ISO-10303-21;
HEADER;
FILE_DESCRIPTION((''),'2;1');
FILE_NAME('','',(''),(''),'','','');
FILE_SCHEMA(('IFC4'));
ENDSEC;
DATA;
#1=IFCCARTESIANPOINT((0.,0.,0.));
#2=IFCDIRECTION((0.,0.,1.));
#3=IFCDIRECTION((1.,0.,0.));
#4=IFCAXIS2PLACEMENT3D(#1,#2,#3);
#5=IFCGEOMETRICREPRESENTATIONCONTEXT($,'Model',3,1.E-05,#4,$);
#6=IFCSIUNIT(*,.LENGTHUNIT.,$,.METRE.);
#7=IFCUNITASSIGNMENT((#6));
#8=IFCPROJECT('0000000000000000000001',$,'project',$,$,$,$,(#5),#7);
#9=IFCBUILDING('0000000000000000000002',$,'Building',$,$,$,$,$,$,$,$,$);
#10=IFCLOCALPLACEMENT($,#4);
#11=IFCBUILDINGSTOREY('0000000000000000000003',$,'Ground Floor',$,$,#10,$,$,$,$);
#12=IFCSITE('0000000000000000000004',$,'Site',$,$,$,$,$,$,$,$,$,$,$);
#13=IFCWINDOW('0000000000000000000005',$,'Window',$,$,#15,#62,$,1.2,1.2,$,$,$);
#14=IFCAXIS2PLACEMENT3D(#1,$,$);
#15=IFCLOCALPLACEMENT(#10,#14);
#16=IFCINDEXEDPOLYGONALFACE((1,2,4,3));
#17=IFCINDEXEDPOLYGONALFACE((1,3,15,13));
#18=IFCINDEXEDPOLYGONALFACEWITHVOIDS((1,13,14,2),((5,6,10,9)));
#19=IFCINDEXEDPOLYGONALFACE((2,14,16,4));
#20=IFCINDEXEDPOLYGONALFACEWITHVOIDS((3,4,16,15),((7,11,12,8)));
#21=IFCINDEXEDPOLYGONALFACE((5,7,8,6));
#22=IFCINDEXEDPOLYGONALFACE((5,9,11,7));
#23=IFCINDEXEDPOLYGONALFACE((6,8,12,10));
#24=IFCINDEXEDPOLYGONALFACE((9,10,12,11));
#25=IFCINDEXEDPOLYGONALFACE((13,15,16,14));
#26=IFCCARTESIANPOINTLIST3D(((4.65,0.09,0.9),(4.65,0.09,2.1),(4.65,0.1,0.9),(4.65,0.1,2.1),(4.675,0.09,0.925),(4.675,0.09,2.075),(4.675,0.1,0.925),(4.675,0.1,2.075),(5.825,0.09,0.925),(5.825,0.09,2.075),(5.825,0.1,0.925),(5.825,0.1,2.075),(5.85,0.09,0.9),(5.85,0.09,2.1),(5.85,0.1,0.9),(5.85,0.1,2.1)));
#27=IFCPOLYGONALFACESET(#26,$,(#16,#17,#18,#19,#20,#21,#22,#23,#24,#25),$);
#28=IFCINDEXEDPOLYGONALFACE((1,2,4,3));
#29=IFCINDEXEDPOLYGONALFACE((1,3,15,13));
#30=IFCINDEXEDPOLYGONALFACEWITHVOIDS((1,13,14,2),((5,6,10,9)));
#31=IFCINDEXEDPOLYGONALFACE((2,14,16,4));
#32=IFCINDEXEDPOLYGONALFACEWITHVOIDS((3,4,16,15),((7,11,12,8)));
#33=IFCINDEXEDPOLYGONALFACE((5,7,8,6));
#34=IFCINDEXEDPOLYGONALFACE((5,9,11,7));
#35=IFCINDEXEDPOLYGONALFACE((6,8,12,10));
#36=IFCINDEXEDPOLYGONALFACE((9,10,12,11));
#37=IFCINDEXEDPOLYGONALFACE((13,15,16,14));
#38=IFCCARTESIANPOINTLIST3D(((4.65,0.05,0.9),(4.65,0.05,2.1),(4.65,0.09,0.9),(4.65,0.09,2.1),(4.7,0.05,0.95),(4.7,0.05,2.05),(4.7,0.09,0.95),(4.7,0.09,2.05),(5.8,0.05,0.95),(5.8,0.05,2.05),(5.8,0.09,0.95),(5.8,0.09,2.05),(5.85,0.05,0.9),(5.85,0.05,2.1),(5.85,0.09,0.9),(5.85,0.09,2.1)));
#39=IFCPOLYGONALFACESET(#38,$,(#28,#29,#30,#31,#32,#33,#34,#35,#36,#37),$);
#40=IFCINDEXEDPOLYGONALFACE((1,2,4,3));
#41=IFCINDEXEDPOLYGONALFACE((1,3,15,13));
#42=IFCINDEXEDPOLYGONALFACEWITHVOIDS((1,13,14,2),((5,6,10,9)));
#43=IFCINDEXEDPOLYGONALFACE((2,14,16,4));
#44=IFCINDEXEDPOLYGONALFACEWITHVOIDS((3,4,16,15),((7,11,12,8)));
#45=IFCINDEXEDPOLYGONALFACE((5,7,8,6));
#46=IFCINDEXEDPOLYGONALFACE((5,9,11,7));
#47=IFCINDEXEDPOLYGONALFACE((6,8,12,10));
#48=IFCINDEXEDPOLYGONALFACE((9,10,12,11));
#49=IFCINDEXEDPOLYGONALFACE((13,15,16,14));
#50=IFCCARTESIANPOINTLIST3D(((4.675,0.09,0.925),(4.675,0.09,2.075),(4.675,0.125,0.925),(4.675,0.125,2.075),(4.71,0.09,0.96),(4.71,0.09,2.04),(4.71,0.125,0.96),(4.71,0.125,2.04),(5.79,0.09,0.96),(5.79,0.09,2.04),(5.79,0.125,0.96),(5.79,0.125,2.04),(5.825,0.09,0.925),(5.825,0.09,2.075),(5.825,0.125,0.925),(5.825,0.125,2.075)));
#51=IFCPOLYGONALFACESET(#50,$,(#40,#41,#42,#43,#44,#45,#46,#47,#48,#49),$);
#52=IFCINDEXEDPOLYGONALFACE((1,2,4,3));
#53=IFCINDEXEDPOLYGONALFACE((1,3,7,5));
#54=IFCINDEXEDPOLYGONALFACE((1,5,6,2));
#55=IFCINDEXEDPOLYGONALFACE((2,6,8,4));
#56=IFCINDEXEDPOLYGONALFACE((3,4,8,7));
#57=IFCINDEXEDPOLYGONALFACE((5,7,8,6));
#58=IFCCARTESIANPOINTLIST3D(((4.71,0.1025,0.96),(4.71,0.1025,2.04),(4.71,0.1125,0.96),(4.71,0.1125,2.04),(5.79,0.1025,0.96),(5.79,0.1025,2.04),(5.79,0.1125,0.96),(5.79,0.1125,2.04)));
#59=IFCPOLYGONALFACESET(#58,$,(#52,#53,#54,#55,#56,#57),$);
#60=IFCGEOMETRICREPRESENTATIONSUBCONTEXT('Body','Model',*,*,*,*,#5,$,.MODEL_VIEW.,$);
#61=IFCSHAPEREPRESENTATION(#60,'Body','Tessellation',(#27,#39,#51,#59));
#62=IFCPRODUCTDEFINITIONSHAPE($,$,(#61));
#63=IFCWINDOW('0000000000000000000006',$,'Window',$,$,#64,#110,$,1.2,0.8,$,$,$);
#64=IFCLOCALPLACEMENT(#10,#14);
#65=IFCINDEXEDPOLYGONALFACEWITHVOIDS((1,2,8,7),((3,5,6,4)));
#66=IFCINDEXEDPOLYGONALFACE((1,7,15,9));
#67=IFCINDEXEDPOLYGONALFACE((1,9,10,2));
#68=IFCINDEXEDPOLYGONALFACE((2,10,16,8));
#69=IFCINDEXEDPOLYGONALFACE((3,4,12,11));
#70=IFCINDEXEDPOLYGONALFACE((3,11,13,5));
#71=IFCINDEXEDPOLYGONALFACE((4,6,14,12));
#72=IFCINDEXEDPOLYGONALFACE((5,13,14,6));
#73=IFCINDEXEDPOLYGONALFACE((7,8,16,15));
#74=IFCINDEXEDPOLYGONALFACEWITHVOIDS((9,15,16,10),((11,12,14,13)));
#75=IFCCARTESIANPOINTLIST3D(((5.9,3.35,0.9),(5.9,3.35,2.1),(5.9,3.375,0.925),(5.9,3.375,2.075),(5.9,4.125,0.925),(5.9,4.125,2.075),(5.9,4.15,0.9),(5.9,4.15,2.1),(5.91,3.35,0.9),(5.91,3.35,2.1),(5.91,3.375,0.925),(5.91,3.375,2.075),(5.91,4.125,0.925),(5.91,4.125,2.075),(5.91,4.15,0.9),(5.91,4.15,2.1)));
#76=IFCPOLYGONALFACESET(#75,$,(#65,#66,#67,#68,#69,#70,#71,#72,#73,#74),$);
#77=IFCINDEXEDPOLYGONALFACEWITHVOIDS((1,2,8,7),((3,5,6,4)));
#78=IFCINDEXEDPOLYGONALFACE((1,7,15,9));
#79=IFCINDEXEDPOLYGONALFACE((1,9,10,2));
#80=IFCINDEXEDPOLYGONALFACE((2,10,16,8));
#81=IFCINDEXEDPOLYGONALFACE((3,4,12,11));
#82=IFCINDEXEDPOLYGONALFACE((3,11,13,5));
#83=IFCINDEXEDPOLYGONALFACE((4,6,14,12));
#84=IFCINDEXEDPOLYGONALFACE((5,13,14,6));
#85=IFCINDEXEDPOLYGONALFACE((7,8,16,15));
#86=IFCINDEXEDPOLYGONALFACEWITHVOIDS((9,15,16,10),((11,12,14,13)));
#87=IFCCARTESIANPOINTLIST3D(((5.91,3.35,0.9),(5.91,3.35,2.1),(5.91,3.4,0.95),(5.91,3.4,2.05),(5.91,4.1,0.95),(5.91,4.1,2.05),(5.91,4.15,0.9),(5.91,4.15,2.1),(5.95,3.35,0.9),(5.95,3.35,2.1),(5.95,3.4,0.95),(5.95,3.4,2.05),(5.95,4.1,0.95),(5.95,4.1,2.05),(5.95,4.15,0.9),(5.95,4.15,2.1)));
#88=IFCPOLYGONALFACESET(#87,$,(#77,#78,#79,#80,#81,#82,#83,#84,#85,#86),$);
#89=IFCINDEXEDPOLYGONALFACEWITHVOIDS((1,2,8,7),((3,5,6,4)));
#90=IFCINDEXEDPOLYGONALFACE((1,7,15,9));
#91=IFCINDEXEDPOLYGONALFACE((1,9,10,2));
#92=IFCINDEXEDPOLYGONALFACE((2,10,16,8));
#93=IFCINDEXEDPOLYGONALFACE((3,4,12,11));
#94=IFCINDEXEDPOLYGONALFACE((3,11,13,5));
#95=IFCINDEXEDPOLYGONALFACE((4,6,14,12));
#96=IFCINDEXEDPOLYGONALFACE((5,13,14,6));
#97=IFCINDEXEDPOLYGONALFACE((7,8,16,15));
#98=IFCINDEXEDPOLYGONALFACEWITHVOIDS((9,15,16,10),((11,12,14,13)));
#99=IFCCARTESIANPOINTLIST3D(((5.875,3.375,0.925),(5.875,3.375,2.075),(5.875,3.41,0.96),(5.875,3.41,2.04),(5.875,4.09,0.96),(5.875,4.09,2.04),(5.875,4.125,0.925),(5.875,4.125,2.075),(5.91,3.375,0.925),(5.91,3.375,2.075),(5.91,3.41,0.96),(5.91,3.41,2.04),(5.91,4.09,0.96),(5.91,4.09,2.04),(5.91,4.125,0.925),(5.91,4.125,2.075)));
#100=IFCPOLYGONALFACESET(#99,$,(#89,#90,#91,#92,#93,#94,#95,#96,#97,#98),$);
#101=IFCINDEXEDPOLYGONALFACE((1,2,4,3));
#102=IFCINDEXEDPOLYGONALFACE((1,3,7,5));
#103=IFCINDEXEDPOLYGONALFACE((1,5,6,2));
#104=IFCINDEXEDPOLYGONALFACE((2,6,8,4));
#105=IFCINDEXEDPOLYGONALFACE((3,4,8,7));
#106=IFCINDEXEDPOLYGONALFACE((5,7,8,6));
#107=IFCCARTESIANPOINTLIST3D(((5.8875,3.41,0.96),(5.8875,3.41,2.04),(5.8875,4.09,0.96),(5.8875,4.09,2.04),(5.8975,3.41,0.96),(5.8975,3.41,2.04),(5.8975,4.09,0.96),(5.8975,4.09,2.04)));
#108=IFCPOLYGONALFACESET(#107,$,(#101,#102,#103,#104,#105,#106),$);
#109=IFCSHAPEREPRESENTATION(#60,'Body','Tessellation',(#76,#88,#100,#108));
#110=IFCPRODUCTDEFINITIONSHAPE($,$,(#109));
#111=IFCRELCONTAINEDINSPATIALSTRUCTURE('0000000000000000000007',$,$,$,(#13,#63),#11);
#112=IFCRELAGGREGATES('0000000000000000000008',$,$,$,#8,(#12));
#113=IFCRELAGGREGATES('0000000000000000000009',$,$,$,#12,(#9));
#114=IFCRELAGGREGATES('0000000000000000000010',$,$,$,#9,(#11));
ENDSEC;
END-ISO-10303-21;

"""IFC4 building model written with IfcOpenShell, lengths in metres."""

from ifc_helpers import new_model, si_unit, frame, origin_with_axes, place, context, subcontext, project, spatial, line, indexed_curve, outline, extrude, element, save


model = new_model("IFC4")

# Units and contexts
model_context = context("Model", 3, precision=1e-05, world=origin_with_axes())
body_context = subcontext(model_context, "Body", "Model", "MODEL_VIEW")
ifc_project = project(units=[si_unit("LENGTHUNIT", "METRE")], contexts=[model_context])

# Site, building, storey
site = spatial("IfcSite", under=ifc_project, Name="Site")
building = spatial("IfcBuilding", under=site, Name="Building")
storey_placement = place(None, origin_with_axes())
storey = spatial("IfcBuildingStorey", under=building, at=storey_placement, Name="Ground Floor")

# Windows
window_1_placement = place(storey_placement, frame((4.65, 0.0, 0.9), z_axis=(0.0, 0.0, 1.0), x_axis=(1.0, 0.0, 0.0)))
element("IfcWindow", 1, at=window_1_placement, inside=storey, Name="Window", OverallHeight=1.2, OverallWidth=1.2, context=body_context, shape_type="SweptSolid", body=[
    extrude(outline(indexed_curve([(0.0, 0.0), (1.2, 0.0), (1.2, 1.2), (0.0, 1.2)], segments=[line(1, 2, 3, 4, 1)]), holes=[indexed_curve([(0.025, 0.025), (1.175, 0.025), (1.175, 1.175), (0.025, 1.175)], segments=[line(1, 2, 3, 4, 1)])]), frame((0.0, 0.09, 0.0), z_axis=(0.0, -1.0, 0.0), x_axis=(1.0, 0.0, 0.0)), (0.0, 0.0, -1.0), 0.01),
    extrude(outline(indexed_curve([(0.0, 0.0), (1.2, 0.0), (1.2, 1.2), (0.0, 1.2)], segments=[line(1, 2, 3, 4, 1)]), holes=[indexed_curve([(0.05, 0.05), (1.15, 0.05), (1.15, 1.15), (0.05, 1.15)], segments=[line(1, 2, 3, 4, 1)])]), frame((0.0, 0.05, 0.0), z_axis=(0.0, -1.0, 0.0), x_axis=(1.0, 0.0, 0.0)), (0.0, 0.0, -1.0), 0.04),
    extrude(outline(indexed_curve([(0.0, 0.0), (1.15, 0.0), (1.15, 1.15), (0.0, 1.15)], segments=[line(1, 2, 3, 4, 1)]), holes=[indexed_curve([(0.035, 0.035), (1.115, 0.035), (1.115, 1.115), (0.035, 1.115)], segments=[line(1, 2, 3, 4, 1)])]), frame((0.025, 0.09, 0.025), z_axis=(0.0, -1.0, 0.0), x_axis=(1.0, 0.0, 0.0)), (0.0, 0.0, -1.0), 0.035),
    extrude(outline(indexed_curve([(0.035, 0.035), (1.115, 0.035), (1.115, 1.115), (0.035, 1.115)], segments=[line(1, 2, 3, 4, 1)])), frame((0.025, 0.1025, 0.025), z_axis=(0.0, -1.0, 0.0), x_axis=(1.0, 0.0, 0.0)), (0.0, 0.0, -1.0), 0.01),
])
window_2_placement = place(storey_placement, frame((6.0, 3.35, 0.9), z_axis=(0.0, 0.0, 1.0), x_axis=(0.0, 1.0, 0.0)))
element("IfcWindow", 2, at=window_2_placement, inside=storey, Name="Window", OverallHeight=1.2, OverallWidth=0.8, context=body_context, shape_type="SweptSolid", body=[
    extrude(outline(indexed_curve([(0.0, 0.0), (0.8, 0.0), (0.8, 1.2), (0.0, 1.2)], segments=[line(1, 2, 3, 4, 1)]), holes=[indexed_curve([(0.025, 0.025), (0.775, 0.025), (0.775, 1.175), (0.025, 1.175)], segments=[line(1, 2, 3, 4, 1)])]), frame((0.0, 0.09, 0.0), z_axis=(0.0, -1.0, 0.0), x_axis=(1.0, 0.0, 0.0)), (0.0, 0.0, -1.0), 0.01),
    extrude(outline(indexed_curve([(0.0, 0.0), (0.8, 0.0), (0.8, 1.2), (0.0, 1.2)], segments=[line(1, 2, 3, 4, 1)]), holes=[indexed_curve([(0.05, 0.05), (0.75, 0.05), (0.75, 1.15), (0.05, 1.15)], segments=[line(1, 2, 3, 4, 1)])]), frame((0.0, 0.05, 0.0), z_axis=(0.0, -1.0, 0.0), x_axis=(1.0, 0.0, 0.0)), (0.0, 0.0, -1.0), 0.04),
    extrude(outline(indexed_curve([(0.0, 0.0), (0.75, 0.0), (0.75, 1.15), (0.0, 1.15)], segments=[line(1, 2, 3, 4, 1)]), holes=[indexed_curve([(0.035, 0.035), (0.715, 0.035), (0.715, 1.115), (0.035, 1.115)], segments=[line(1, 2, 3, 4, 1)])]), frame((0.025, 0.09, 0.025), z_axis=(0.0, -1.0, 0.0), x_axis=(1.0, 0.0, 0.0)), (0.0, 0.0, -1.0), 0.035),
    extrude(outline(indexed_curve([(0.035, 0.035), (0.715, 0.035), (0.715, 1.115), (0.035, 1.115)], segments=[line(1, 2, 3, 4, 1)])), frame((0.025, 0.1025, 0.025), z_axis=(0.0, -1.0, 0.0), x_axis=(1.0, 0.0, 0.0)), (0.0, 0.0, -1.0), 0.01),
])

save(model, "model.ifc")
